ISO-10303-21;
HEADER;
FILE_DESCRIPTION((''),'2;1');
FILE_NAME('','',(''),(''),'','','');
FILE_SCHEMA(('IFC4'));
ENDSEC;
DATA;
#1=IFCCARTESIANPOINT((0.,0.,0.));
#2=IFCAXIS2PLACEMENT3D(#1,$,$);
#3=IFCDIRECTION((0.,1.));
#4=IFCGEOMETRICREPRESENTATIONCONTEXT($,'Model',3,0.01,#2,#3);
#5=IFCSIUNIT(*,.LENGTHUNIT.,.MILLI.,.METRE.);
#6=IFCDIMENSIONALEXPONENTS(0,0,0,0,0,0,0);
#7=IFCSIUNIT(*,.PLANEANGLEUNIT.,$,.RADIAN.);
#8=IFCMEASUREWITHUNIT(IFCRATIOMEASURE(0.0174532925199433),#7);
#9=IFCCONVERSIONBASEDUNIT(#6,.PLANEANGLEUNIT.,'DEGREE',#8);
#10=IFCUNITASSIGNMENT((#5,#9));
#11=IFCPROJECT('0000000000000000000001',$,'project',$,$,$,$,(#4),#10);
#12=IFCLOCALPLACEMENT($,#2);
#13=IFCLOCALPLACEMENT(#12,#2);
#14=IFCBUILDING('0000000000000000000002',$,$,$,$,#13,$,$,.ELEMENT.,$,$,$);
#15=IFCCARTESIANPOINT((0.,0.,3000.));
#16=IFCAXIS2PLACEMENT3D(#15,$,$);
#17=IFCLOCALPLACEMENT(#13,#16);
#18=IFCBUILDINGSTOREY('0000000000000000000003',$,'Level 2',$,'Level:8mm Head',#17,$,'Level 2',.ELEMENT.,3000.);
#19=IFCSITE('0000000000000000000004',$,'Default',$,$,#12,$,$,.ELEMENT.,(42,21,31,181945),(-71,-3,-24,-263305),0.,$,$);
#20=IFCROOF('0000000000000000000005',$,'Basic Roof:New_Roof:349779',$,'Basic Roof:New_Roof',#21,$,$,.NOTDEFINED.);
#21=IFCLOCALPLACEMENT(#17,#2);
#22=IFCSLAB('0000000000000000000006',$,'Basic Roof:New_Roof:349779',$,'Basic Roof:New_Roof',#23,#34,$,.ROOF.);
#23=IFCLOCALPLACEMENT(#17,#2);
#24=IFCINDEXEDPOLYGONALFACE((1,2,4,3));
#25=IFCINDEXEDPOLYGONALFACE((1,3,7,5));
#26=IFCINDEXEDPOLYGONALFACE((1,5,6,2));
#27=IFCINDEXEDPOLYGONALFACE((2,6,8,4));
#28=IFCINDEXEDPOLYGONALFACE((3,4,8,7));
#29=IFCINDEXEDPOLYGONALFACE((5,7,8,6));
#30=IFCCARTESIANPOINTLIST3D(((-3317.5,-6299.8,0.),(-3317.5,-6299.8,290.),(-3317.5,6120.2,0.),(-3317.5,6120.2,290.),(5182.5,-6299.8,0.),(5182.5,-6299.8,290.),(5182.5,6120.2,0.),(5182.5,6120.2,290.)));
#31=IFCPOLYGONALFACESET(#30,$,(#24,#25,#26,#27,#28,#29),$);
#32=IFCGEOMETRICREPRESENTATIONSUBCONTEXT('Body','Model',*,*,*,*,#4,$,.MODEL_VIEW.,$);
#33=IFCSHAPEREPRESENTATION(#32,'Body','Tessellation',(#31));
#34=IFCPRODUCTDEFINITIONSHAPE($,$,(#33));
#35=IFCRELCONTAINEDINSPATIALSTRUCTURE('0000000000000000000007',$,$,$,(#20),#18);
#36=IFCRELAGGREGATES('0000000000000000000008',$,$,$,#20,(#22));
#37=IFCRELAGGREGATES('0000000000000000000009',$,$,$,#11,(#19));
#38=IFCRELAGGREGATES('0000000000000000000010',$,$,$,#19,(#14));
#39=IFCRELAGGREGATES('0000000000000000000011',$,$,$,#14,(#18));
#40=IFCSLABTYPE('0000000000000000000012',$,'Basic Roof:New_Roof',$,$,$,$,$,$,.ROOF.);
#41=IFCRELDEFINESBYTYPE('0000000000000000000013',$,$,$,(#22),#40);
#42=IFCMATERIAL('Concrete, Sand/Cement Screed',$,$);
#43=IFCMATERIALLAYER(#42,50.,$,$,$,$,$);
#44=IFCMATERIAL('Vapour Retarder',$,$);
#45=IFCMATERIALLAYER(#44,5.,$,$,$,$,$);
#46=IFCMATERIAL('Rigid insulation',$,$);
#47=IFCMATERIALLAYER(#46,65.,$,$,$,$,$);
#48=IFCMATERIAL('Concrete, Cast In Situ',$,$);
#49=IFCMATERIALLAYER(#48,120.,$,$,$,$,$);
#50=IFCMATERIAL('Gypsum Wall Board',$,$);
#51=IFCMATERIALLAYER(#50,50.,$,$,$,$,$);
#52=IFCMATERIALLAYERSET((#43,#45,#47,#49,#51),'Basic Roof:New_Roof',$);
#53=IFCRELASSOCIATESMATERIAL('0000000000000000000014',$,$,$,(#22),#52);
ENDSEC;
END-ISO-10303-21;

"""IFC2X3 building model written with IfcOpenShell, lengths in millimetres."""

from ifc_helpers import new_model, entity, si_unit, converted_unit, direction, frame, frame_2d, origin, place, context, subcontext, project, spatial, rectangle, extrude, material, layer, layer_set, type_object, element, aggregate, save


model = new_model("IFC2X3")

# Units and contexts
model_context = context("Model", 3, precision=0.01, world=origin(), true_north=direction((0.0, 1.0)))
body_context = subcontext(model_context, "Body", "Model", "MODEL_VIEW")
ifc_project = project(units=[si_unit("LENGTHUNIT", "METRE", prefix="MILLI"), converted_unit("PLANEANGLEUNIT", "DEGREE", entity("IfcRatioMeasure", 0.0174532925199433), si_unit("PLANEANGLEUNIT", "RADIAN"), dimensions=[0, 0, 0, 0, 0, 0, 0])], contexts=[model_context])

# Site, building, storey
site_placement = place(None, origin())
site = spatial("IfcSite", under=ifc_project, at=site_placement, Name="Default", CompositionType="ELEMENT", RefLatitude=(42, 21, 31, 181945), RefLongitude=(-71, -3, -24, -263305), RefElevation=0.0)
building_placement = place(site_placement, origin())
building = spatial("IfcBuilding", under=site, at=building_placement, CompositionType="ELEMENT")
storey_placement = place(building_placement, frame((0.0, 0.0, 3000.0)))
storey = spatial("IfcBuildingStorey", under=building, at=storey_placement, Name="Level 2", ObjectType="Level:8mm Head", LongName="Level 2", CompositionType="ELEMENT", Elevation=3000.0)

# Roof, slab
roof_placement = place(storey_placement, frame((-3317.5, -6299.8, 0.0)))
roof = element("IfcRoof", 1, at=roof_placement, inside=storey, Name="Basic Roof:New_Roof:349779", ObjectType="Basic Roof:New_Roof", ShapeType="NOTDEFINED")
ifc_material_1 = material(Name="Concrete, Sand/Cement Screed")
ifc_layer_1 = layer(ifc_material_1, 50.0)
ifc_material_2 = material(Name="Vapour Retarder")
ifc_layer_2 = layer(ifc_material_2, 5.0)
ifc_material_3 = material(Name="Rigid insulation")
ifc_layer_3 = layer(ifc_material_3, 65.0)
ifc_material_4 = material(Name="Concrete, Cast In Situ")
ifc_layer_4 = layer(ifc_material_4, 120.0)
ifc_material_5 = material(Name="Gypsum Wall Board")
ifc_layer_5 = layer(ifc_material_5, 50.0)
ifc_layer_set = layer_set([ifc_layer_1, ifc_layer_2, ifc_layer_3, ifc_layer_4, ifc_layer_5], Name="Basic Roof:New_Roof")
slab_type = type_object("IfcSlabType", Name="Basic Roof:New_Roof", PredefinedType="ROOF")
slab_placement = place(roof_placement, origin())
slab = element("IfcSlab", 2, at=slab_placement, type_object=slab_type, material=ifc_layer_set, Name="Basic Roof:New_Roof:349779", ObjectType="Basic Roof:New_Roof", PredefinedType="ROOF", context=body_context, shape_type="SweptSolid", body=[
    extrude(rectangle(XDim=12420.0, YDim=8500.0, at=frame_2d((0.0, 0.0), x_axis=(0.0, 1.0))), frame((4250.0, 6210.0, 0.0)), (0.0, 0.0, 1.0), 290.0),
])
aggregate(roof, [slab])

save(model, "model.ifc")
